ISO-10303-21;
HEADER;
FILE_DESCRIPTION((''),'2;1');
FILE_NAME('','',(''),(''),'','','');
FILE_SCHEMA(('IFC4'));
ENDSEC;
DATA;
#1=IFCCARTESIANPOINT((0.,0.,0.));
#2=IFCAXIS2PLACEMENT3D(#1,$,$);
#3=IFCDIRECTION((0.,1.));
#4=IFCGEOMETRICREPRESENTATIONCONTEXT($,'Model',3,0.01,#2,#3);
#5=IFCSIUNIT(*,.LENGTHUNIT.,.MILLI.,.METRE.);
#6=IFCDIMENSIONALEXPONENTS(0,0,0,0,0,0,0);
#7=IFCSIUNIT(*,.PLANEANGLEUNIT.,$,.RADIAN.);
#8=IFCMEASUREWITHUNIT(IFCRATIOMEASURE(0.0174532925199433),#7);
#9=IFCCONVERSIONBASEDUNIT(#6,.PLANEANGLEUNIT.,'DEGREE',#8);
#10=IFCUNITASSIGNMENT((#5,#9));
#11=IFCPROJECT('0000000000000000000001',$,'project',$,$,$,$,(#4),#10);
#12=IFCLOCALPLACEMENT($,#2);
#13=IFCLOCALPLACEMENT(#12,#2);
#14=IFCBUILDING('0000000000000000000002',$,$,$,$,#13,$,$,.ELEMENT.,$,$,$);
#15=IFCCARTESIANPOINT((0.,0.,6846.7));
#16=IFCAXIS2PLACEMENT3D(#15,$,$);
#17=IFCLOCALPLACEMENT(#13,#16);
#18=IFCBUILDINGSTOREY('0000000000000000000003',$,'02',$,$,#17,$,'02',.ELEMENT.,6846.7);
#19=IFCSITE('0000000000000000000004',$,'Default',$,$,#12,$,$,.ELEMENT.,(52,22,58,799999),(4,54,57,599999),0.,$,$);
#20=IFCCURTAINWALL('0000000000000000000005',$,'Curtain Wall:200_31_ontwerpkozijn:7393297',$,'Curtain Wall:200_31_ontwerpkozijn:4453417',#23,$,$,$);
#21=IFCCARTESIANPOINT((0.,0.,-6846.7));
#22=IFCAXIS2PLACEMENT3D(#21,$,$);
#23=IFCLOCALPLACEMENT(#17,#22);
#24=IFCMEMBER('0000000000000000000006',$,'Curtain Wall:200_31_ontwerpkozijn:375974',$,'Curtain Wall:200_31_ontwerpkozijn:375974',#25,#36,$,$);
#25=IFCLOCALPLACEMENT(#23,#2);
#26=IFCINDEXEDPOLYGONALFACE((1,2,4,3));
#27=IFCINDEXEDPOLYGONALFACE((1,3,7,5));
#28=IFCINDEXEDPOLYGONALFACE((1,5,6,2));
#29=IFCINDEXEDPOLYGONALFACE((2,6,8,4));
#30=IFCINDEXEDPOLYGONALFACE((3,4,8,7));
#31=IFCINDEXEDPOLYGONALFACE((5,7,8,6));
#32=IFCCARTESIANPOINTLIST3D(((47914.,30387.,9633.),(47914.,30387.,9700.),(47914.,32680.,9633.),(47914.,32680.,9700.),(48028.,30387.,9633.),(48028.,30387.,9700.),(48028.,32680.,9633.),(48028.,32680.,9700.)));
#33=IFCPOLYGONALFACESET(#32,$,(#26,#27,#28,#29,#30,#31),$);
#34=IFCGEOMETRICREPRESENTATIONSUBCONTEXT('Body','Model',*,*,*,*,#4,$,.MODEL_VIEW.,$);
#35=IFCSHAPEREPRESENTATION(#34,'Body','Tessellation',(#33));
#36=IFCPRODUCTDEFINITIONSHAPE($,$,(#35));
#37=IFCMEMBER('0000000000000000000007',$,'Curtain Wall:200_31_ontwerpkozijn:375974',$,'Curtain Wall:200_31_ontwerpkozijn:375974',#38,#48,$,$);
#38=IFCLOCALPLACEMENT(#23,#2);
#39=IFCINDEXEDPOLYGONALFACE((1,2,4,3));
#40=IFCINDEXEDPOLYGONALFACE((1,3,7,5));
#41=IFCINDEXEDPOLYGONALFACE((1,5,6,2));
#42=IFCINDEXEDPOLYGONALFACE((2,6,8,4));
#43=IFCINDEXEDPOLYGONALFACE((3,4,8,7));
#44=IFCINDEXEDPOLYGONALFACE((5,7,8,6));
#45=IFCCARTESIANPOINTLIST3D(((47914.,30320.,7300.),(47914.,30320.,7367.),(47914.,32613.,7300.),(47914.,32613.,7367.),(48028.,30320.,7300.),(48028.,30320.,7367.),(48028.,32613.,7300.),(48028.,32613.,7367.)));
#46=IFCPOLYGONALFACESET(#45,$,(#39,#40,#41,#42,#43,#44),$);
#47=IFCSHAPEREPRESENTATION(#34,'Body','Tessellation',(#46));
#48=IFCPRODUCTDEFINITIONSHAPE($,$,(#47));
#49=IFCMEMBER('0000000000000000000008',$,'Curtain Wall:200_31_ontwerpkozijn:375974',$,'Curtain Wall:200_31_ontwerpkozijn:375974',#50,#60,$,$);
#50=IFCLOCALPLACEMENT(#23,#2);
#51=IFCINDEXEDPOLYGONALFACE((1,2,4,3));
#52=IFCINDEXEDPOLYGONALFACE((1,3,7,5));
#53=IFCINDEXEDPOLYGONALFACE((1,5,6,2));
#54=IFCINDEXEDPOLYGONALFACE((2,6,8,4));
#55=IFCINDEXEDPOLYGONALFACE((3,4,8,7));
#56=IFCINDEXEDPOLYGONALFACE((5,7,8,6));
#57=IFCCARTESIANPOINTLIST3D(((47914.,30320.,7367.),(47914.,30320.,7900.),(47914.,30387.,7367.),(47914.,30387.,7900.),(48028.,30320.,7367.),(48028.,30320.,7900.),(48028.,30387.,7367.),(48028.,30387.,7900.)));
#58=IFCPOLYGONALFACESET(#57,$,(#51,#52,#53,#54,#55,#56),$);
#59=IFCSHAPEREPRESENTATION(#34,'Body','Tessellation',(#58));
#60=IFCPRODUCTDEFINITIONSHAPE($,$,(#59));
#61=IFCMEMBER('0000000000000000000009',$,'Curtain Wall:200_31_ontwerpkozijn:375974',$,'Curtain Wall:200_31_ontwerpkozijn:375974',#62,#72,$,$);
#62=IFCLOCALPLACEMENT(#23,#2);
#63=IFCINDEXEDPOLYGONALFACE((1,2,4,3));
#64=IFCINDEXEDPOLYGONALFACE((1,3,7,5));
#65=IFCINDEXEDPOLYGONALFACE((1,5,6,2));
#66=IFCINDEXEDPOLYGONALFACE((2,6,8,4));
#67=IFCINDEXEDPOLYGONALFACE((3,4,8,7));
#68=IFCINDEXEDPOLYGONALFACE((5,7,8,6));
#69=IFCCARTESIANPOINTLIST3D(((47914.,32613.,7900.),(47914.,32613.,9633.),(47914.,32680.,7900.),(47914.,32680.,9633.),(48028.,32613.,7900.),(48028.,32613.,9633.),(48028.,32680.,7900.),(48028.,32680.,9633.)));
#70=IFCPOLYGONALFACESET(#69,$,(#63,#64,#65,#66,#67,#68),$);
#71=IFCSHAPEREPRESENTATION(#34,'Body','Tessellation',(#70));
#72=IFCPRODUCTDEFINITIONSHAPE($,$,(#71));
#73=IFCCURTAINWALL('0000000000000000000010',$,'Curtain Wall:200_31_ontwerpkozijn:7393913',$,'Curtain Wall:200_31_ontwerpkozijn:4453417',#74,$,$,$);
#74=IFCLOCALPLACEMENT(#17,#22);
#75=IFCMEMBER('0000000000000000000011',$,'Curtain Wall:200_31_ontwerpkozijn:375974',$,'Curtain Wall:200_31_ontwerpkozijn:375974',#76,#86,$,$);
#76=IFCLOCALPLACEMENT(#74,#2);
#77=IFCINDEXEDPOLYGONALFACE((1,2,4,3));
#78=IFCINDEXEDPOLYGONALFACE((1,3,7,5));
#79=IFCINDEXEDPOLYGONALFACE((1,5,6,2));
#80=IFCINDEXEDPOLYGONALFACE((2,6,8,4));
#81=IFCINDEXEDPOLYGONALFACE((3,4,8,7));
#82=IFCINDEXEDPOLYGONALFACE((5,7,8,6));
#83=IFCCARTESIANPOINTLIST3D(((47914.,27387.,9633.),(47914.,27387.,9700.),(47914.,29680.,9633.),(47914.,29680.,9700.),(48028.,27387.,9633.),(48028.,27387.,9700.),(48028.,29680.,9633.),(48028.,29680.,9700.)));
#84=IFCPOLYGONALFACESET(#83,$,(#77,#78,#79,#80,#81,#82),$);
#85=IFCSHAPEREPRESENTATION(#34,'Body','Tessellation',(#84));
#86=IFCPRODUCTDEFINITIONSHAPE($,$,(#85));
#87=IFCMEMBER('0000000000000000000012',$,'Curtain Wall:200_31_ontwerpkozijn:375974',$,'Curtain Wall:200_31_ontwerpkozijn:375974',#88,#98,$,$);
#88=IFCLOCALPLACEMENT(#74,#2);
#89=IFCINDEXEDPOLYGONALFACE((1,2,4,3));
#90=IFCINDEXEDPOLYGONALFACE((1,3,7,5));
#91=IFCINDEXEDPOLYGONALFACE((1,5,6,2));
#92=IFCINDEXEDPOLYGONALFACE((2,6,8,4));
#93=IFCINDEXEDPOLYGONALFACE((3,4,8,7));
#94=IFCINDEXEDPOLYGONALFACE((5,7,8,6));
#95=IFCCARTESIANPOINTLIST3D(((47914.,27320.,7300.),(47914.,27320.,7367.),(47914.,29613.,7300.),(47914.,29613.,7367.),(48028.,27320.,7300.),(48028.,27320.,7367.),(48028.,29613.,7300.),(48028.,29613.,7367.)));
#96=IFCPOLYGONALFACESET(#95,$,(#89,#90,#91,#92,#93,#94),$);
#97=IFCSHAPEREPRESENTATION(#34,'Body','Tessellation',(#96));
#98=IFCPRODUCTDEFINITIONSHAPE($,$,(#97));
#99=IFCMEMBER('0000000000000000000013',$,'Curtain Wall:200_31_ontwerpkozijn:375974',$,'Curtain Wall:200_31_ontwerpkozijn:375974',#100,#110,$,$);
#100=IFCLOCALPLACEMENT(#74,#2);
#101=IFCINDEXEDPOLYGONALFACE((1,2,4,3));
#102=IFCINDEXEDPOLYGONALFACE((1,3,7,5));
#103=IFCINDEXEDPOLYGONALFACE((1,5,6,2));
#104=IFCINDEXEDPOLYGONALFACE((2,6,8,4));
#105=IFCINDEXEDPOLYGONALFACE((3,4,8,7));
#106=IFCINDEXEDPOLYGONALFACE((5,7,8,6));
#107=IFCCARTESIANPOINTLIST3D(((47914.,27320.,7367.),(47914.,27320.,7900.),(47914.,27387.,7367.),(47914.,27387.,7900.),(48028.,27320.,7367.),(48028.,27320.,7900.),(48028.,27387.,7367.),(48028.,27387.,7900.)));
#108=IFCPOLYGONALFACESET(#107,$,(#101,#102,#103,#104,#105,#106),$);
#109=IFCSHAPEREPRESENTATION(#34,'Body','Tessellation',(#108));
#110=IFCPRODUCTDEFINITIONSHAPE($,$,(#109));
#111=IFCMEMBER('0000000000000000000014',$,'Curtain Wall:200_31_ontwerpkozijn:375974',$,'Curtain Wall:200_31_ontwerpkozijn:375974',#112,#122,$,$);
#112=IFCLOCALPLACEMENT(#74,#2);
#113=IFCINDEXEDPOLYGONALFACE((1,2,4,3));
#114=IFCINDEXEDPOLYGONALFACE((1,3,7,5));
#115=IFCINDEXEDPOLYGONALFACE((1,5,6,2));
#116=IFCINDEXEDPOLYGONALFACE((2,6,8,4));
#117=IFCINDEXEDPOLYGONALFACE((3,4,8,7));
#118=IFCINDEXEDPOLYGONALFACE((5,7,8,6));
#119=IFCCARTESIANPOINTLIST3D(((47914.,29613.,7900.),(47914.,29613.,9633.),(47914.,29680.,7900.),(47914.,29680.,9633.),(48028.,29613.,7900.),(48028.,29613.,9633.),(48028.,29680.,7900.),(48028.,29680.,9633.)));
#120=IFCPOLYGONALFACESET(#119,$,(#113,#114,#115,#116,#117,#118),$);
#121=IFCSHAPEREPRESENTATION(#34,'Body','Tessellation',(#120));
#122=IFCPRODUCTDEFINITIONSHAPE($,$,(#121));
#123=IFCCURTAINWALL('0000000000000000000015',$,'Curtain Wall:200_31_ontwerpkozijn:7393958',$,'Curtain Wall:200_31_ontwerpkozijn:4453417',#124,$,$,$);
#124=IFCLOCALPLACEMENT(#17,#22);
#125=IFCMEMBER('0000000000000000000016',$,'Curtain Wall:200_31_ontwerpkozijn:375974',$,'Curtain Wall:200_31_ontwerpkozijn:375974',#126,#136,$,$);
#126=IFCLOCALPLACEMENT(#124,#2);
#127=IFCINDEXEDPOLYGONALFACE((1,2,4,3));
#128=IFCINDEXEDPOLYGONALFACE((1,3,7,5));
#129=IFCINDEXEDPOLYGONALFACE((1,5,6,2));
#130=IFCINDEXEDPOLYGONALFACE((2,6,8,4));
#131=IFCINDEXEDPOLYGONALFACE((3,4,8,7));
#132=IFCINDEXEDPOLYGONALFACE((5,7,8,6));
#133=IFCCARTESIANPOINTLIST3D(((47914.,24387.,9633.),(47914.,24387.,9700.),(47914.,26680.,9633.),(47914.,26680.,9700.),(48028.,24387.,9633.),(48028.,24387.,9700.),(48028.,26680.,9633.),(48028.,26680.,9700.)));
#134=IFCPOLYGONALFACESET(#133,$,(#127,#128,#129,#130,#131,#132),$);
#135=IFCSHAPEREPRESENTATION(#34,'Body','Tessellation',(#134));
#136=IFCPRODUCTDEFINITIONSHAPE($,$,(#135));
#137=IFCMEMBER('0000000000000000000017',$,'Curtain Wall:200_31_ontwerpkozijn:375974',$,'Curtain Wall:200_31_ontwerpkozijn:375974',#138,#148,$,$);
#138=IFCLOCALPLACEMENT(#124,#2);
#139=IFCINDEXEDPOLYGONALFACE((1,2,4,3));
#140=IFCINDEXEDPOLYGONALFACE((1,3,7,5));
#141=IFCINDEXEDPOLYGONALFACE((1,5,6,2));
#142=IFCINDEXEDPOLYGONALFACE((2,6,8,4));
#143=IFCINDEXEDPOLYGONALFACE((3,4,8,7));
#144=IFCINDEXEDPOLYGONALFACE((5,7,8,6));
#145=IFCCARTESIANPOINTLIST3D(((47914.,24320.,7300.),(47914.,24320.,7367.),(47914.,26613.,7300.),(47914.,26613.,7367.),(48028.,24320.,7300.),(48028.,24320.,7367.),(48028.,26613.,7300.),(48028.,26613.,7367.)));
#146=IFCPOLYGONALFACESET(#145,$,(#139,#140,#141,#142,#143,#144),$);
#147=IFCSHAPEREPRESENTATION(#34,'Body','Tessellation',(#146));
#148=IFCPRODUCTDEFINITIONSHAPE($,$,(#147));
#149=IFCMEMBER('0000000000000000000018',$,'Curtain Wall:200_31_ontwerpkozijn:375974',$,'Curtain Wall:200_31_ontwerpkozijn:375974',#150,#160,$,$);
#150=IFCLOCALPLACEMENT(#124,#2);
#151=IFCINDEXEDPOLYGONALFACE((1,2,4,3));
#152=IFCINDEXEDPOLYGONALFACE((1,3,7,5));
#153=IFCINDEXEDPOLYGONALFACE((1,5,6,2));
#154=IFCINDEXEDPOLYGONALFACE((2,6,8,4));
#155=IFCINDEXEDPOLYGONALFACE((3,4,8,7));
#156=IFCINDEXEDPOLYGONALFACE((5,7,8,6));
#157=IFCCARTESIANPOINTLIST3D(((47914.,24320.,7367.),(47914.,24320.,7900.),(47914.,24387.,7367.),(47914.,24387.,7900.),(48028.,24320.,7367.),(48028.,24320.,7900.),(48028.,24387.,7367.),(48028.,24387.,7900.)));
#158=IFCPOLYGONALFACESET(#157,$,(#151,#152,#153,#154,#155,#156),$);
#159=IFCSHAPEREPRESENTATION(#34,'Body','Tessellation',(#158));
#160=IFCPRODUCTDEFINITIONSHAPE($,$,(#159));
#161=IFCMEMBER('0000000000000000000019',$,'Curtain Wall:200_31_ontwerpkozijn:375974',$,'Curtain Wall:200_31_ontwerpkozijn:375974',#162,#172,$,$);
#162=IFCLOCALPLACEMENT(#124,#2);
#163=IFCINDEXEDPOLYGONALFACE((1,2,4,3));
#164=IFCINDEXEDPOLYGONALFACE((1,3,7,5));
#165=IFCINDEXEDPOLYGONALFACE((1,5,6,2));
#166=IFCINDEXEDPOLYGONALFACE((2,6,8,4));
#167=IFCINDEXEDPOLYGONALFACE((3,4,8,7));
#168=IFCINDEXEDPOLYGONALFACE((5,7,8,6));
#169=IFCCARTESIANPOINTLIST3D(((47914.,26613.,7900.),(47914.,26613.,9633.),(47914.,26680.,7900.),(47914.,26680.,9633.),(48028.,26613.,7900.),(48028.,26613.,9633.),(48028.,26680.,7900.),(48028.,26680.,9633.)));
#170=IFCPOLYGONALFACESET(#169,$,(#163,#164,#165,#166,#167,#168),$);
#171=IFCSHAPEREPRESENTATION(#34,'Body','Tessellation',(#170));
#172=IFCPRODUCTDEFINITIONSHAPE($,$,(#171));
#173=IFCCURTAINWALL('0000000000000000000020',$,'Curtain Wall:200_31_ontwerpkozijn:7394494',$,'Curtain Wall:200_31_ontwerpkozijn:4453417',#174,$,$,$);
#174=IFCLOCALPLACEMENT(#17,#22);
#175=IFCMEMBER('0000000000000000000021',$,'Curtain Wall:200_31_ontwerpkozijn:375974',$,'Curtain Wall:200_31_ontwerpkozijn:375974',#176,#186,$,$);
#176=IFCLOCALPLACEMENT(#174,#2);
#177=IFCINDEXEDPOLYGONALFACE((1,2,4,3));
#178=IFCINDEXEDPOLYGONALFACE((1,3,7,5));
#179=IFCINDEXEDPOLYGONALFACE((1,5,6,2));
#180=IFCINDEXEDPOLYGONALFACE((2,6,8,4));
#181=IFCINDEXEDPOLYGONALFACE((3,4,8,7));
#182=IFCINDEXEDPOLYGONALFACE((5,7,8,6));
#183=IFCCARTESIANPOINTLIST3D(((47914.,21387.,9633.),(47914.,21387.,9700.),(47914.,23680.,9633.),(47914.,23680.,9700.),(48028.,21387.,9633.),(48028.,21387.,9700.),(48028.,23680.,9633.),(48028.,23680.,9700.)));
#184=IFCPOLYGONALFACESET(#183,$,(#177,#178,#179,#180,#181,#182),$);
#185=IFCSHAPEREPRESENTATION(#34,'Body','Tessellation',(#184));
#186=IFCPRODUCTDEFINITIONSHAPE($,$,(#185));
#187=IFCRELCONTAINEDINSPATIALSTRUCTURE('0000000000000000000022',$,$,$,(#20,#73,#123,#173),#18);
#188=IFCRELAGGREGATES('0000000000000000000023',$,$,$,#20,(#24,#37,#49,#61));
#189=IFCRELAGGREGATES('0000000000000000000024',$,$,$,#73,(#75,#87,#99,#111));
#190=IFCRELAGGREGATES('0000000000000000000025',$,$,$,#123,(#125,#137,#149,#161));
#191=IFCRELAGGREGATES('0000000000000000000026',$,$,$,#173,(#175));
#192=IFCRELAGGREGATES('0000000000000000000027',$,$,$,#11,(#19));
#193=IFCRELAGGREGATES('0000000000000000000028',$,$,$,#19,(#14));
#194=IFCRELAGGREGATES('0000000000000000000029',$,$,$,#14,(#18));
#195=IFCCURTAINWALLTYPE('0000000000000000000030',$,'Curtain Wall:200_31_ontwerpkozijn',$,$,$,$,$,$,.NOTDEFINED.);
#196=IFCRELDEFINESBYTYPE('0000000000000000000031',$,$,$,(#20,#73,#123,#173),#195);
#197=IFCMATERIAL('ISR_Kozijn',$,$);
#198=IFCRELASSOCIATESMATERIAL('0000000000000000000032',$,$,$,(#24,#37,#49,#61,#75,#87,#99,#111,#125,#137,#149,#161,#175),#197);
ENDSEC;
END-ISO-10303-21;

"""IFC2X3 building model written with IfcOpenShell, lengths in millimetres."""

from ifc_helpers import new_model, entity, si_unit, converted_unit, direction, frame, frame_2d, origin, place, context, subcontext, project, spatial, rectangle, extrude, material, type_object, element, aggregate, save


model = new_model("IFC2X3")

# Units and contexts
model_context = context("Model", 3, precision=0.01, world=origin(), true_north=direction((0.0, 1.0)))
body_context = subcontext(model_context, "Body", "Model", "MODEL_VIEW")
ifc_project = project(units=[si_unit("LENGTHUNIT", "METRE", prefix="MILLI"), converted_unit("PLANEANGLEUNIT", "DEGREE", entity("IfcRatioMeasure", 0.0174532925199433), si_unit("PLANEANGLEUNIT", "RADIAN"), dimensions=[0, 0, 0, 0, 0, 0, 0])], contexts=[model_context])

# Site, building, storey
site_placement = place(None, origin())
site = spatial("IfcSite", under=ifc_project, at=site_placement, Name="Default", CompositionType="ELEMENT", RefLatitude=(52, 22, 58, 799999), RefLongitude=(4, 54, 57, 599999), RefElevation=0.0)
building_placement = place(site_placement, origin())
building = spatial("IfcBuilding", under=site, at=building_placement, CompositionType="ELEMENT")
storey_placement = place(building_placement, frame((0.0, 0.0, 6846.7)))
storey = spatial("IfcBuildingStorey", under=building, at=storey_placement, Name="02", LongName="02", CompositionType="ELEMENT", Elevation=6846.7)

# Curtain walls, members
curtain_wall_type = type_object("IfcCurtainWallType", Name="Curtain Wall:200_31_ontwerpkozijn", PredefinedType="NOTDEFINED")
curtain_wall_1_placement = place(storey_placement, frame((0.0, 0.0, -6846.7)))
curtain_wall_1 = element("IfcCurtainWall", 1, at=curtain_wall_1_placement, inside=storey, type_object=curtain_wall_type, Name="Curtain Wall:200_31_ontwerpkozijn:7393297", ObjectType="Curtain Wall:200_31_ontwerpkozijn:4453417")
ifc_material = material(Name="ISR_Kozijn")
member_1_placement = place(curtain_wall_1_placement, origin())
member_1 = element("IfcMember", 2, at=member_1_placement, material=ifc_material, Name="Curtain Wall:200_31_ontwerpkozijn:375974", ObjectType="Curtain Wall:200_31_ontwerpkozijn:375974", context=body_context, shape_type="SweptSolid", body=[
    extrude(rectangle(XDim=67.0, YDim=114.0, at=frame_2d((0.0, 0.0), x_axis=(1.0, 0.0))), frame((47971.0, 30387.0, 9666.5), z_axis=(0.0, 1.0, 0.0), x_axis=(0.0, 0.0, -1.0)), (0.0, 0.0, 1.0), 2293.0),
])
member_2_placement = place(curtain_wall_1_placement, origin())
member_2 = element("IfcMember", 3, at=member_2_placement, material=ifc_material, Name="Curtain Wall:200_31_ontwerpkozijn:375974", ObjectType="Curtain Wall:200_31_ontwerpkozijn:375974", context=body_context, shape_type="SweptSolid", body=[
    extrude(rectangle(XDim=67.0, YDim=114.0, at=frame_2d((0.0, 0.0), x_axis=(1.0, 0.0))), frame((47971.0, 32613.0, 7333.5), z_axis=(0.0, -1.0, 0.0), x_axis=(0.0, 0.0, -1.0)), (0.0, 0.0, 1.0), 2293.0),
])
member_3_placement = place(curtain_wall_1_placement, origin())
member_3 = element("IfcMember", 4, at=member_3_placement, material=ifc_material, Name="Curtain Wall:200_31_ontwerpkozijn:375974", ObjectType="Curtain Wall:200_31_ontwerpkozijn:375974", context=body_context, shape_type="SweptSolid", body=[
    extrude(rectangle(XDim=114.0, YDim=67.0, at=frame_2d((0.0, 0.0), x_axis=(1.0, 0.0))), frame((47971.0, 30353.5, 7367.0), z_axis=(0.0, 0.0, 1.0), x_axis=(-1.0, 0.0, 0.0)), (0.0, 0.0, 1.0), 533.0),
])
member_4_placement = place(curtain_wall_1_placement, origin())
member_4 = element("IfcMember", 5, at=member_4_placement, material=ifc_material, Name="Curtain Wall:200_31_ontwerpkozijn:375974", ObjectType="Curtain Wall:200_31_ontwerpkozijn:375974", context=body_context, shape_type="SweptSolid", body=[
    extrude(rectangle(XDim=114.0, YDim=67.0, at=frame_2d((0.0, 0.0), x_axis=(1.0, 0.0))), frame((47971.0, 32646.5, 9633.0), z_axis=(0.0, 0.0, -1.0), x_axis=(-1.0, 0.0, 0.0)), (0.0, 0.0, 1.0), 1733.0),
])
aggregate(curtain_wall_1, [member_1, member_2, member_3, member_4])
curtain_wall_2_placement = place(storey_placement, frame((0.0, 0.0, -6846.7)))
curtain_wall_2 = element("IfcCurtainWall", 6, at=curtain_wall_2_placement, inside=storey, type_object=curtain_wall_type, Name="Curtain Wall:200_31_ontwerpkozijn:7393913", ObjectType="Curtain Wall:200_31_ontwerpkozijn:4453417")
member_5_placement = place(curtain_wall_2_placement, origin())
member_5 = element("IfcMember", 7, at=member_5_placement, material=ifc_material, Name="Curtain Wall:200_31_ontwerpkozijn:375974", ObjectType="Curtain Wall:200_31_ontwerpkozijn:375974", context=body_context, shape_type="SweptSolid", body=[
    extrude(rectangle(XDim=67.0, YDim=114.0, at=frame_2d((0.0, 0.0), x_axis=(1.0, 0.0))), frame((47971.0, 27387.0, 9666.5), z_axis=(0.0, 1.0, 0.0), x_axis=(0.0, 0.0, -1.0)), (0.0, 0.0, 1.0), 2293.0),
])
member_6_placement = place(curtain_wall_2_placement, origin())
member_6 = element("IfcMember", 8, at=member_6_placement, material=ifc_material, Name="Curtain Wall:200_31_ontwerpkozijn:375974", ObjectType="Curtain Wall:200_31_ontwerpkozijn:375974", context=body_context, shape_type="SweptSolid", body=[
    extrude(rectangle(XDim=67.0, YDim=114.0, at=frame_2d((0.0, 0.0), x_axis=(1.0, 0.0))), frame((47971.0, 29613.0, 7333.5), z_axis=(0.0, -1.0, 0.0), x_axis=(0.0, 0.0, -1.0)), (0.0, 0.0, 1.0), 2293.0),
])
member_7_placement = place(curtain_wall_2_placement, origin())
member_7 = element("IfcMember", 9, at=member_7_placement, material=ifc_material, Name="Curtain Wall:200_31_ontwerpkozijn:375974", ObjectType="Curtain Wall:200_31_ontwerpkozijn:375974", context=body_context, shape_type="SweptSolid", body=[
    extrude(rectangle(XDim=114.0, YDim=67.0, at=frame_2d((0.0, 0.0), x_axis=(1.0, 0.0))), frame((47971.0, 27353.5, 7367.0), z_axis=(0.0, 0.0, 1.0), x_axis=(-1.0, 0.0, 0.0)), (0.0, 0.0, 1.0), 533.0),
])
member_8_placement = place(curtain_wall_2_placement, origin())
member_8 = element("IfcMember", 10, at=member_8_placement, material=ifc_material, Name="Curtain Wall:200_31_ontwerpkozijn:375974", ObjectType="Curtain Wall:200_31_ontwerpkozijn:375974", context=body_context, shape_type="SweptSolid", body=[
    extrude(rectangle(XDim=114.0, YDim=67.0, at=frame_2d((0.0, 0.0), x_axis=(1.0, 0.0))), frame((47971.0, 29646.5, 9633.0), z_axis=(0.0, 0.0, -1.0), x_axis=(-1.0, 0.0, 0.0)), (0.0, 0.0, 1.0), 1733.0),
])
aggregate(curtain_wall_2, [member_5, member_6, member_7, member_8])
curtain_wall_3_placement = place(storey_placement, frame((0.0, 0.0, -6846.7)))
curtain_wall_3 = element("IfcCurtainWall", 11, at=curtain_wall_3_placement, inside=storey, type_object=curtain_wall_type, Name="Curtain Wall:200_31_ontwerpkozijn:7393958", ObjectType="Curtain Wall:200_31_ontwerpkozijn:4453417")
member_9_placement = place(curtain_wall_3_placement, origin())
member_9 = element("IfcMember", 12, at=member_9_placement, material=ifc_material, Name="Curtain Wall:200_31_ontwerpkozijn:375974", ObjectType="Curtain Wall:200_31_ontwerpkozijn:375974", context=body_context, shape_type="SweptSolid", body=[
    extrude(rectangle(XDim=67.0, YDim=114.0, at=frame_2d((0.0, 0.0), x_axis=(1.0, 0.0))), frame((47971.0, 24387.0, 9666.5), z_axis=(0.0, 1.0, 0.0), x_axis=(0.0, 0.0, -1.0)), (0.0, 0.0, 1.0), 2293.0),
])
member_10_placement = place(curtain_wall_3_placement, origin())
member_10 = element("IfcMember", 13, at=member_10_placement, material=ifc_material, Name="Curtain Wall:200_31_ontwerpkozijn:375974", ObjectType="Curtain Wall:200_31_ontwerpkozijn:375974", context=body_context, shape_type="SweptSolid", body=[
    extrude(rectangle(XDim=67.0, YDim=114.0, at=frame_2d((0.0, 0.0), x_axis=(1.0, 0.0))), frame((47971.0, 26613.0, 7333.5), z_axis=(0.0, -1.0, 0.0), x_axis=(0.0, 0.0, -1.0)), (0.0, 0.0, 1.0), 2293.0),
])
member_11_placement = place(curtain_wall_3_placement, origin())
member_11 = element("IfcMember", 14, at=member_11_placement, material=ifc_material, Name="Curtain Wall:200_31_ontwerpkozijn:375974", ObjectType="Curtain Wall:200_31_ontwerpkozijn:375974", context=body_context, shape_type="SweptSolid", body=[
    extrude(rectangle(XDim=114.0, YDim=67.0, at=frame_2d((0.0, 0.0), x_axis=(1.0, 0.0))), frame((47971.0, 24353.5, 7367.0), z_axis=(0.0, 0.0, 1.0), x_axis=(-1.0, 0.0, 0.0)), (0.0, 0.0, 1.0), 533.0),
])
member_12_placement = place(curtain_wall_3_placement, origin())
member_12 = element("IfcMember", 15, at=member_12_placement, material=ifc_material, Name="Curtain Wall:200_31_ontwerpkozijn:375974", ObjectType="Curtain Wall:200_31_ontwerpkozijn:375974", context=body_context, shape_type="SweptSolid", body=[
    extrude(rectangle(XDim=114.0, YDim=67.0, at=frame_2d((0.0, 0.0), x_axis=(1.0, 0.0))), frame((47971.0, 26646.5, 9633.0), z_axis=(0.0, 0.0, -1.0), x_axis=(-1.0, 0.0, 0.0)), (0.0, 0.0, 1.0), 1733.0),
])
aggregate(curtain_wall_3, [member_9, member_10, member_11, member_12])
curtain_wall_4_placement = place(storey_placement, frame((0.0, 0.0, -6846.7)))
curtain_wall_4 = element("IfcCurtainWall", 16, at=curtain_wall_4_placement, inside=storey, type_object=curtain_wall_type, Name="Curtain Wall:200_31_ontwerpkozijn:7394494", ObjectType="Curtain Wall:200_31_ontwerpkozijn:4453417")
member_13_placement = place(curtain_wall_4_placement, origin())
member_13 = element("IfcMember", 17, at=member_13_placement, material=ifc_material, Name="Curtain Wall:200_31_ontwerpkozijn:375974", ObjectType="Curtain Wall:200_31_ontwerpkozijn:375974", context=body_context, shape_type="SweptSolid", body=[
    extrude(rectangle(XDim=67.0, YDim=114.0, at=frame_2d((0.0, 0.0), x_axis=(1.0, 0.0))), frame((47971.0, 21387.0, 9666.5), z_axis=(0.0, 1.0, 0.0), x_axis=(0.0, 0.0, -1.0)), (0.0, 0.0, 1.0), 2293.0),
])
aggregate(curtain_wall_4, [member_13])

save(model, "model.ifc")
